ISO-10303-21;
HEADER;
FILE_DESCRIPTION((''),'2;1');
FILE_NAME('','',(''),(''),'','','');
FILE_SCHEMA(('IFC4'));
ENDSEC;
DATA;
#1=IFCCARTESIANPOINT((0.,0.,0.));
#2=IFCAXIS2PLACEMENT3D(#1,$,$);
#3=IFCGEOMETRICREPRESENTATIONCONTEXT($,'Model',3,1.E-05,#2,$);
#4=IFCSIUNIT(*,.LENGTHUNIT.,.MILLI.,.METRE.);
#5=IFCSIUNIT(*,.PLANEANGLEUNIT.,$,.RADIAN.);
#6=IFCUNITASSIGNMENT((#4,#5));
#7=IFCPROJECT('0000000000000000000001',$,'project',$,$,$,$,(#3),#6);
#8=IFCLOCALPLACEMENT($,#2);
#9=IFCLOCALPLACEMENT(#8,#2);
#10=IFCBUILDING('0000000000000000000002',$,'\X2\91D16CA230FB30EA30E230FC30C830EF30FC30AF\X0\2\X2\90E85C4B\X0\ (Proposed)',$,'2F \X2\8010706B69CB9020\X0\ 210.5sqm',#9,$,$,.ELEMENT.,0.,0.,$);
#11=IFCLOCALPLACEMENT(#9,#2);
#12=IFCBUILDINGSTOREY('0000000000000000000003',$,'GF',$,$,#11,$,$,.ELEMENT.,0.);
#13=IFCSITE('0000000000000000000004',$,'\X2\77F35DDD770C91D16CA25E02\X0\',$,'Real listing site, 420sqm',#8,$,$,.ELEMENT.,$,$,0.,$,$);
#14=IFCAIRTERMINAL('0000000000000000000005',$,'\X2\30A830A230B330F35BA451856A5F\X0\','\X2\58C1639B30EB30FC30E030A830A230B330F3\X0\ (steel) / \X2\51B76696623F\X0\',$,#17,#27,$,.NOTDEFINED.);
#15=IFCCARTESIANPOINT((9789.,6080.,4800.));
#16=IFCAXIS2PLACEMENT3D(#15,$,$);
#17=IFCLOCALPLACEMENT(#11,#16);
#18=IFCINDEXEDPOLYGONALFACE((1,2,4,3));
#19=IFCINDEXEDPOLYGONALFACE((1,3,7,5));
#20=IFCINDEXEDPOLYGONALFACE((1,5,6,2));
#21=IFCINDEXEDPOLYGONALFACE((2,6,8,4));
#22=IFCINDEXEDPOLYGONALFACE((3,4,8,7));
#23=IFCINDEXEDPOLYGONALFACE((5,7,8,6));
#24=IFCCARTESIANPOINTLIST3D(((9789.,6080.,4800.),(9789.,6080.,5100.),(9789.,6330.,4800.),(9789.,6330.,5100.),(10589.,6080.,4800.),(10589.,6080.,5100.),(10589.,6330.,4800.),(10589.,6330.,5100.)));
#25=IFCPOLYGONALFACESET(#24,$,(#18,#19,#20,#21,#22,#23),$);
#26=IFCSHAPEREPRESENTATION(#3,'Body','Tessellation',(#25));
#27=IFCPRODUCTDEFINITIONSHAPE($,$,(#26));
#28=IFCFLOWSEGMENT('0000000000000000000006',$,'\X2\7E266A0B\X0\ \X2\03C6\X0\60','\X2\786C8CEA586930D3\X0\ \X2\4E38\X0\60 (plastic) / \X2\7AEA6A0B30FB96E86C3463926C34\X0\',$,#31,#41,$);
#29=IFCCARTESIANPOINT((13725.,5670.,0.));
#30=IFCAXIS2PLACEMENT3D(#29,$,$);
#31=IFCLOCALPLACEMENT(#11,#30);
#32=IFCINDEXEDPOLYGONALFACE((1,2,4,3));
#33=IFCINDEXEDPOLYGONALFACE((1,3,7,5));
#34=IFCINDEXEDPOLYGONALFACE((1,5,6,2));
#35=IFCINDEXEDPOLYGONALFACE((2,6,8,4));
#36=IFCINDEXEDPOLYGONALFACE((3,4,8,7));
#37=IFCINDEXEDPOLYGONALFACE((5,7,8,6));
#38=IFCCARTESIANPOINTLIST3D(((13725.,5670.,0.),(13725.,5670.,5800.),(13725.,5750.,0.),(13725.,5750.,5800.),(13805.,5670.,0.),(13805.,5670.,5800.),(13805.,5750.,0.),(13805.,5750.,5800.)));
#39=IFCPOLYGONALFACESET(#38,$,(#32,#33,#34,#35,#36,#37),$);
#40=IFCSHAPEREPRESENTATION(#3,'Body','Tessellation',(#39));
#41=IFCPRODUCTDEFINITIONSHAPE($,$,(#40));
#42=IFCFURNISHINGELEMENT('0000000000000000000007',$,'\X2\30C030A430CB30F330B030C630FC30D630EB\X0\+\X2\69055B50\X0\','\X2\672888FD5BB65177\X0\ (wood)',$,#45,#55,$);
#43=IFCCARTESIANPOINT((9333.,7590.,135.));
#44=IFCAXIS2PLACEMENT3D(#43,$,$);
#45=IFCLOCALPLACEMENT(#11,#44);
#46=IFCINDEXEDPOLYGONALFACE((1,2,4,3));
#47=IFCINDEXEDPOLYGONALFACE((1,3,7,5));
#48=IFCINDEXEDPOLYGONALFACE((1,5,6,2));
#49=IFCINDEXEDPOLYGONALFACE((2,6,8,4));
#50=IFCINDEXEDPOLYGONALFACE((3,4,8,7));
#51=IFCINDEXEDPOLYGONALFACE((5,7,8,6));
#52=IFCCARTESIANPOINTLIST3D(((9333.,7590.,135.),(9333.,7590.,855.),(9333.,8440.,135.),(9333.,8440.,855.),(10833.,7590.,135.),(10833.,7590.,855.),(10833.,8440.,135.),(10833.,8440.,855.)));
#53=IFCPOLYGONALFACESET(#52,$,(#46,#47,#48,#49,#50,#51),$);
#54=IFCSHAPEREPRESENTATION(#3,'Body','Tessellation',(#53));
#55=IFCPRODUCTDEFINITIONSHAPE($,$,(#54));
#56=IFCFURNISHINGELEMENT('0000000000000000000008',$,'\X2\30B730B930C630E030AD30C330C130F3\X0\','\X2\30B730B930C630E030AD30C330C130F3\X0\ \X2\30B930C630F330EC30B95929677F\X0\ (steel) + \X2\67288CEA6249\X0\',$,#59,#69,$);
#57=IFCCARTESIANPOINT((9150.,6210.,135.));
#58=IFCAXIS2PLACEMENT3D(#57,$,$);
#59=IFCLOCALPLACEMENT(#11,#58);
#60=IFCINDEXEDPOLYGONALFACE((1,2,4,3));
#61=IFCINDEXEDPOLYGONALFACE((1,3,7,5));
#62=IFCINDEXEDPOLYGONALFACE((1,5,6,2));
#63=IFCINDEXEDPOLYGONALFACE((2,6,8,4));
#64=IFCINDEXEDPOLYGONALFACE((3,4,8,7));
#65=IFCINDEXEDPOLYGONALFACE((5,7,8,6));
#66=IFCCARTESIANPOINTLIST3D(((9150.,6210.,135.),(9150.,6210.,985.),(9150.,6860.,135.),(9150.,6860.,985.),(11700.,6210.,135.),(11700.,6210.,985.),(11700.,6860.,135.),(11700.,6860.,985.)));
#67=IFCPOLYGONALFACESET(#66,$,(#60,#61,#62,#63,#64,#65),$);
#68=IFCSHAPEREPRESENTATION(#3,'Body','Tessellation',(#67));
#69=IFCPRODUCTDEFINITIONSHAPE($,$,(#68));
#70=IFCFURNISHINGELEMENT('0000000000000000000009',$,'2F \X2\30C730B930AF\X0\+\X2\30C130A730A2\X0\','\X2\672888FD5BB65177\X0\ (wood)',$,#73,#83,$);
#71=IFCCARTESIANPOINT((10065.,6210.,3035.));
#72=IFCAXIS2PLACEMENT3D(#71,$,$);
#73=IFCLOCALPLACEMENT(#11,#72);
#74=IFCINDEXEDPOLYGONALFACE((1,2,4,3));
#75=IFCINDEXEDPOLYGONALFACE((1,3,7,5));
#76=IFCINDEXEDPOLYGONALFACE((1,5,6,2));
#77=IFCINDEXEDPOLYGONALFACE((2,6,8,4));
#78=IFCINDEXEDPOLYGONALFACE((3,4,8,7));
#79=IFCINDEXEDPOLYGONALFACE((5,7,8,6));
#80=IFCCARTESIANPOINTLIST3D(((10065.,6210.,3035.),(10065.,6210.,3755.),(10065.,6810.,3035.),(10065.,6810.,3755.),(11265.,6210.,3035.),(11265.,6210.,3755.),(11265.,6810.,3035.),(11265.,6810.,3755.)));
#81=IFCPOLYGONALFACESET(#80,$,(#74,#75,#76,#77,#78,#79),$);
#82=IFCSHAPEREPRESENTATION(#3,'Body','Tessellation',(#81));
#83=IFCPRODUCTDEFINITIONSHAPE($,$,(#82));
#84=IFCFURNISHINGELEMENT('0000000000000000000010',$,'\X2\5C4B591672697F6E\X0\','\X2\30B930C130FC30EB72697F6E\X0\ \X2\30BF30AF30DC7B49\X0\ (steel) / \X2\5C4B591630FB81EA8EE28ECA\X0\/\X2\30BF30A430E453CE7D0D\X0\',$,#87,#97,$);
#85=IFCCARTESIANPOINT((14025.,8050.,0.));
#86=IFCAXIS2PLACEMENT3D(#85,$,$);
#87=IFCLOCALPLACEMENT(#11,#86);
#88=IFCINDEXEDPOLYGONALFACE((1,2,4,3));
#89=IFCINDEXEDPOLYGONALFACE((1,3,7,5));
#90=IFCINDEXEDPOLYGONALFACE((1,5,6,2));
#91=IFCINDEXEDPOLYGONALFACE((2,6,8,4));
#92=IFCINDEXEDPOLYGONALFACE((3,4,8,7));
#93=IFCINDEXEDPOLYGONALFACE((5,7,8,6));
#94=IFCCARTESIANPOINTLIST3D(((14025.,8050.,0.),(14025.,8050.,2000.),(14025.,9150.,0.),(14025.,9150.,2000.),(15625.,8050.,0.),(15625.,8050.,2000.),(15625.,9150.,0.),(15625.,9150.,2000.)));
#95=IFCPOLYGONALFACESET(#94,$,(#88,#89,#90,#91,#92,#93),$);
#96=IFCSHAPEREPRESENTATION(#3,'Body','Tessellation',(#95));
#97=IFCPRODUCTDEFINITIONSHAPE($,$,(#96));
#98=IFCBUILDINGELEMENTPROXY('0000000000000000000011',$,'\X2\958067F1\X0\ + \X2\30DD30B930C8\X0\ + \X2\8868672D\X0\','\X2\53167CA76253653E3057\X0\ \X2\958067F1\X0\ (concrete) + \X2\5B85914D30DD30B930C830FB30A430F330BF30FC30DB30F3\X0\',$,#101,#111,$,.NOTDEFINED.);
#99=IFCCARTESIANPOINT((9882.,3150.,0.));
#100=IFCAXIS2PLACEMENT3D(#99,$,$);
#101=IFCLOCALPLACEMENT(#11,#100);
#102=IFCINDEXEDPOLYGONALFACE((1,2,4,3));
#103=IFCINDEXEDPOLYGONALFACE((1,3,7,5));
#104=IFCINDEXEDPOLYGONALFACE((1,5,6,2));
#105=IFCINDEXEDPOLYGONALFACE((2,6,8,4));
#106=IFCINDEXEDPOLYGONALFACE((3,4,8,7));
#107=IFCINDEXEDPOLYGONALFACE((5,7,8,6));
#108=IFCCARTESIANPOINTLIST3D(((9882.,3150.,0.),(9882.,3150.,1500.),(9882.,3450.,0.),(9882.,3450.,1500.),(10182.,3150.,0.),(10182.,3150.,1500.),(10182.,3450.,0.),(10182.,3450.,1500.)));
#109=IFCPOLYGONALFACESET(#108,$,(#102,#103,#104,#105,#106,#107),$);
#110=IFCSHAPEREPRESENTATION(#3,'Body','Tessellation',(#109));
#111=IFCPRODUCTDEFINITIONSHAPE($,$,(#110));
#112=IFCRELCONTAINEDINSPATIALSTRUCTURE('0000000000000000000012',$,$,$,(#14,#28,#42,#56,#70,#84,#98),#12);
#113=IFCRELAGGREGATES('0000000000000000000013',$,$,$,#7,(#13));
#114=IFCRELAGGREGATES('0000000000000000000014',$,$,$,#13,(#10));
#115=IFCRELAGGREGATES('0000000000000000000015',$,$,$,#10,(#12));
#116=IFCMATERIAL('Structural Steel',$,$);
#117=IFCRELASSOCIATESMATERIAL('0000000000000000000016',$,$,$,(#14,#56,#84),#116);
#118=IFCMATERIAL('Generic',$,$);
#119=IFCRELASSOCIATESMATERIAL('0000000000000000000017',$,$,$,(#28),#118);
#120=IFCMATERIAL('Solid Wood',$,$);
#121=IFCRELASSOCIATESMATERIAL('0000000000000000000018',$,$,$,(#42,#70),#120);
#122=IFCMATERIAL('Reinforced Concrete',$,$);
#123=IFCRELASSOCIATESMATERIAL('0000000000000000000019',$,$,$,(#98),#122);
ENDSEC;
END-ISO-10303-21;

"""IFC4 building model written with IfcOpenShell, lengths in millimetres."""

from ifc_helpers import new_model, si_unit, frame, frame_2d, origin, place, context, project, spatial, rectangle, extrude, material, element, save


model = new_model("IFC4")

# Units and contexts
model_context = context("Model", 3, precision=1e-05, world=origin())
ifc_project = project(units=[si_unit("LENGTHUNIT", "METRE", prefix="MILLI"), si_unit("PLANEANGLEUNIT", "RADIAN")], contexts=[model_context])

# Site, building, storey
site_placement = place(None, origin())
site = spatial("IfcSite", under=ifc_project, at=site_placement, Name="石川県金沢市", ObjectType="Real listing site, 420sqm", CompositionType="ELEMENT", RefElevation=0.0)
building_placement = place(site_placement, origin())
building = spatial("IfcBuilding", under=site, at=building_placement, Name="金沢・リモートワーク2部屋 (Proposed)", ObjectType="2F 耐火構造 210.5sqm", CompositionType="ELEMENT", ElevationOfRefHeight=0.0, ElevationOfTerrain=0.0)
storey_placement = place(building_placement, origin())
storey = spatial("IfcBuildingStorey", under=building, at=storey_placement, Name="GF", CompositionType="ELEMENT", Elevation=0.0)

# Shared definitions
ifc_material_1 = material(Name="Solid Wood")

# Shared definitions
ifc_material_2 = material(Name="Reinforced Concrete")

# Shared definitions
ifc_material_3 = material(Name="Structural Steel")

# Shared definitions
ifc_material_4 = material(Name="Generic")

# Air terminal
air_terminal_placement = place(storey_placement, frame((9789.0, 6080.0, 4800.0)))
element("IfcAirTerminal", 1, at=air_terminal_placement, inside=storey, material=ifc_material_3, Name="エアコン室内機", Description="壁掛ルームエアコン (steel) / 冷暖房", PredefinedType="NOTDEFINED", context=model_context, shape_type="SweptSolid", body=[
    extrude(rectangle(XDim=800.0, YDim=250.0, at=frame_2d((400.0, 125.0))), frame((9789.0, 6080.0, 4800.0)), (0.0, 0.0, 1.0), 300.0),
])

# Flow segment
flow_segment_placement = place(storey_placement, frame((13725.0, 5670.0, 0.0)))
element("IfcFlowSegment", 2, at=flow_segment_placement, inside=storey, material=ifc_material_4, Name="縦樋 φ60", Description="硬質塩ビ 丸60 (plastic) / 竪樋・雨水排水", context=model_context, shape_type="SweptSolid", body=[
    extrude(rectangle(XDim=80.0, YDim=80.0, at=frame_2d((40.0, 40.0))), frame((13725.0, 5670.0, 0.0)), (0.0, 0.0, 1.0), 5800.0),
])

# Furnishing elements
furnishing_1_placement = place(storey_placement, frame((9333.0, 7590.0, 135.0)))
element("IfcFurnishingElement", 3, at=furnishing_1_placement, inside=storey, material=ifc_material_1, Name="ダイニングテーブル+椅子", Description="木製家具 (wood)", context=model_context, shape_type="SweptSolid", body=[
    extrude(rectangle(XDim=1500.0, YDim=850.0, at=frame_2d((750.0, 425.0))), frame((9333.0, 7590.0, 135.0)), (0.0, 0.0, 1.0), 720.0),
])
furnishing_2_placement = place(storey_placement, frame((9150.0, 6210.0, 135.0)))
element("IfcFurnishingElement", 4, at=furnishing_2_placement, inside=storey, material=ifc_material_3, Name="システムキッチン", Description="システムキッチン ステンレス天板 (steel) + 木質扉", context=model_context, shape_type="SweptSolid", body=[
    extrude(rectangle(XDim=2550.0, YDim=650.0, at=frame_2d((1275.0, 325.0))), frame((9150.0, 6210.0, 135.0)), (0.0, 0.0, 1.0), 850.0),
])
furnishing_3_placement = place(storey_placement, frame((10065.0, 6210.0, 3035.0)))
element("IfcFurnishingElement", 5, at=furnishing_3_placement, inside=storey, material=ifc_material_1, Name="2F デスク+チェア", Description="木製家具 (wood)", context=model_context, shape_type="SweptSolid", body=[
    extrude(rectangle(XDim=1200.0, YDim=600.0, at=frame_2d((600.0, 300.0))), frame((10065.0, 6210.0, 3035.0)), (0.0, 0.0, 1.0), 720.0),
])
furnishing_4_placement = place(storey_placement, frame((14025.0, 8050.0, 0.0)))
element("IfcFurnishingElement", 6, at=furnishing_4_placement, inside=storey, material=ifc_material_3, Name="屋外物置", Description="スチール物置 タクボ等 (steel) / 屋外・自転車/タイヤ収納", context=model_context, shape_type="SweptSolid", body=[
    extrude(rectangle(XDim=1600.0, YDim=1100.0, at=frame_2d((800.0, 550.0))), frame((14025.0, 8050.0, 0.0)), (0.0, 0.0, 1.0), 2000.0),
])

# Building element proxy
proxy_placement = place(storey_placement, frame((9882.0, 3150.0, 0.0)))
element("IfcBuildingElementProxy", 7, at=proxy_placement, inside=storey, material=ifc_material_2, Name="門柱 + ポスト + 表札", Description="化粧打放し 門柱 (concrete) + 宅配ポスト・インターホン", PredefinedType="NOTDEFINED", context=model_context, shape_type="SweptSolid", body=[
    extrude(rectangle(XDim=300.0, YDim=300.0, at=frame_2d((150.0, 150.0))), frame((9882.0, 3150.0, 0.0)), (0.0, 0.0, 1.0), 1500.0),
])

save(model, "model.ifc")
